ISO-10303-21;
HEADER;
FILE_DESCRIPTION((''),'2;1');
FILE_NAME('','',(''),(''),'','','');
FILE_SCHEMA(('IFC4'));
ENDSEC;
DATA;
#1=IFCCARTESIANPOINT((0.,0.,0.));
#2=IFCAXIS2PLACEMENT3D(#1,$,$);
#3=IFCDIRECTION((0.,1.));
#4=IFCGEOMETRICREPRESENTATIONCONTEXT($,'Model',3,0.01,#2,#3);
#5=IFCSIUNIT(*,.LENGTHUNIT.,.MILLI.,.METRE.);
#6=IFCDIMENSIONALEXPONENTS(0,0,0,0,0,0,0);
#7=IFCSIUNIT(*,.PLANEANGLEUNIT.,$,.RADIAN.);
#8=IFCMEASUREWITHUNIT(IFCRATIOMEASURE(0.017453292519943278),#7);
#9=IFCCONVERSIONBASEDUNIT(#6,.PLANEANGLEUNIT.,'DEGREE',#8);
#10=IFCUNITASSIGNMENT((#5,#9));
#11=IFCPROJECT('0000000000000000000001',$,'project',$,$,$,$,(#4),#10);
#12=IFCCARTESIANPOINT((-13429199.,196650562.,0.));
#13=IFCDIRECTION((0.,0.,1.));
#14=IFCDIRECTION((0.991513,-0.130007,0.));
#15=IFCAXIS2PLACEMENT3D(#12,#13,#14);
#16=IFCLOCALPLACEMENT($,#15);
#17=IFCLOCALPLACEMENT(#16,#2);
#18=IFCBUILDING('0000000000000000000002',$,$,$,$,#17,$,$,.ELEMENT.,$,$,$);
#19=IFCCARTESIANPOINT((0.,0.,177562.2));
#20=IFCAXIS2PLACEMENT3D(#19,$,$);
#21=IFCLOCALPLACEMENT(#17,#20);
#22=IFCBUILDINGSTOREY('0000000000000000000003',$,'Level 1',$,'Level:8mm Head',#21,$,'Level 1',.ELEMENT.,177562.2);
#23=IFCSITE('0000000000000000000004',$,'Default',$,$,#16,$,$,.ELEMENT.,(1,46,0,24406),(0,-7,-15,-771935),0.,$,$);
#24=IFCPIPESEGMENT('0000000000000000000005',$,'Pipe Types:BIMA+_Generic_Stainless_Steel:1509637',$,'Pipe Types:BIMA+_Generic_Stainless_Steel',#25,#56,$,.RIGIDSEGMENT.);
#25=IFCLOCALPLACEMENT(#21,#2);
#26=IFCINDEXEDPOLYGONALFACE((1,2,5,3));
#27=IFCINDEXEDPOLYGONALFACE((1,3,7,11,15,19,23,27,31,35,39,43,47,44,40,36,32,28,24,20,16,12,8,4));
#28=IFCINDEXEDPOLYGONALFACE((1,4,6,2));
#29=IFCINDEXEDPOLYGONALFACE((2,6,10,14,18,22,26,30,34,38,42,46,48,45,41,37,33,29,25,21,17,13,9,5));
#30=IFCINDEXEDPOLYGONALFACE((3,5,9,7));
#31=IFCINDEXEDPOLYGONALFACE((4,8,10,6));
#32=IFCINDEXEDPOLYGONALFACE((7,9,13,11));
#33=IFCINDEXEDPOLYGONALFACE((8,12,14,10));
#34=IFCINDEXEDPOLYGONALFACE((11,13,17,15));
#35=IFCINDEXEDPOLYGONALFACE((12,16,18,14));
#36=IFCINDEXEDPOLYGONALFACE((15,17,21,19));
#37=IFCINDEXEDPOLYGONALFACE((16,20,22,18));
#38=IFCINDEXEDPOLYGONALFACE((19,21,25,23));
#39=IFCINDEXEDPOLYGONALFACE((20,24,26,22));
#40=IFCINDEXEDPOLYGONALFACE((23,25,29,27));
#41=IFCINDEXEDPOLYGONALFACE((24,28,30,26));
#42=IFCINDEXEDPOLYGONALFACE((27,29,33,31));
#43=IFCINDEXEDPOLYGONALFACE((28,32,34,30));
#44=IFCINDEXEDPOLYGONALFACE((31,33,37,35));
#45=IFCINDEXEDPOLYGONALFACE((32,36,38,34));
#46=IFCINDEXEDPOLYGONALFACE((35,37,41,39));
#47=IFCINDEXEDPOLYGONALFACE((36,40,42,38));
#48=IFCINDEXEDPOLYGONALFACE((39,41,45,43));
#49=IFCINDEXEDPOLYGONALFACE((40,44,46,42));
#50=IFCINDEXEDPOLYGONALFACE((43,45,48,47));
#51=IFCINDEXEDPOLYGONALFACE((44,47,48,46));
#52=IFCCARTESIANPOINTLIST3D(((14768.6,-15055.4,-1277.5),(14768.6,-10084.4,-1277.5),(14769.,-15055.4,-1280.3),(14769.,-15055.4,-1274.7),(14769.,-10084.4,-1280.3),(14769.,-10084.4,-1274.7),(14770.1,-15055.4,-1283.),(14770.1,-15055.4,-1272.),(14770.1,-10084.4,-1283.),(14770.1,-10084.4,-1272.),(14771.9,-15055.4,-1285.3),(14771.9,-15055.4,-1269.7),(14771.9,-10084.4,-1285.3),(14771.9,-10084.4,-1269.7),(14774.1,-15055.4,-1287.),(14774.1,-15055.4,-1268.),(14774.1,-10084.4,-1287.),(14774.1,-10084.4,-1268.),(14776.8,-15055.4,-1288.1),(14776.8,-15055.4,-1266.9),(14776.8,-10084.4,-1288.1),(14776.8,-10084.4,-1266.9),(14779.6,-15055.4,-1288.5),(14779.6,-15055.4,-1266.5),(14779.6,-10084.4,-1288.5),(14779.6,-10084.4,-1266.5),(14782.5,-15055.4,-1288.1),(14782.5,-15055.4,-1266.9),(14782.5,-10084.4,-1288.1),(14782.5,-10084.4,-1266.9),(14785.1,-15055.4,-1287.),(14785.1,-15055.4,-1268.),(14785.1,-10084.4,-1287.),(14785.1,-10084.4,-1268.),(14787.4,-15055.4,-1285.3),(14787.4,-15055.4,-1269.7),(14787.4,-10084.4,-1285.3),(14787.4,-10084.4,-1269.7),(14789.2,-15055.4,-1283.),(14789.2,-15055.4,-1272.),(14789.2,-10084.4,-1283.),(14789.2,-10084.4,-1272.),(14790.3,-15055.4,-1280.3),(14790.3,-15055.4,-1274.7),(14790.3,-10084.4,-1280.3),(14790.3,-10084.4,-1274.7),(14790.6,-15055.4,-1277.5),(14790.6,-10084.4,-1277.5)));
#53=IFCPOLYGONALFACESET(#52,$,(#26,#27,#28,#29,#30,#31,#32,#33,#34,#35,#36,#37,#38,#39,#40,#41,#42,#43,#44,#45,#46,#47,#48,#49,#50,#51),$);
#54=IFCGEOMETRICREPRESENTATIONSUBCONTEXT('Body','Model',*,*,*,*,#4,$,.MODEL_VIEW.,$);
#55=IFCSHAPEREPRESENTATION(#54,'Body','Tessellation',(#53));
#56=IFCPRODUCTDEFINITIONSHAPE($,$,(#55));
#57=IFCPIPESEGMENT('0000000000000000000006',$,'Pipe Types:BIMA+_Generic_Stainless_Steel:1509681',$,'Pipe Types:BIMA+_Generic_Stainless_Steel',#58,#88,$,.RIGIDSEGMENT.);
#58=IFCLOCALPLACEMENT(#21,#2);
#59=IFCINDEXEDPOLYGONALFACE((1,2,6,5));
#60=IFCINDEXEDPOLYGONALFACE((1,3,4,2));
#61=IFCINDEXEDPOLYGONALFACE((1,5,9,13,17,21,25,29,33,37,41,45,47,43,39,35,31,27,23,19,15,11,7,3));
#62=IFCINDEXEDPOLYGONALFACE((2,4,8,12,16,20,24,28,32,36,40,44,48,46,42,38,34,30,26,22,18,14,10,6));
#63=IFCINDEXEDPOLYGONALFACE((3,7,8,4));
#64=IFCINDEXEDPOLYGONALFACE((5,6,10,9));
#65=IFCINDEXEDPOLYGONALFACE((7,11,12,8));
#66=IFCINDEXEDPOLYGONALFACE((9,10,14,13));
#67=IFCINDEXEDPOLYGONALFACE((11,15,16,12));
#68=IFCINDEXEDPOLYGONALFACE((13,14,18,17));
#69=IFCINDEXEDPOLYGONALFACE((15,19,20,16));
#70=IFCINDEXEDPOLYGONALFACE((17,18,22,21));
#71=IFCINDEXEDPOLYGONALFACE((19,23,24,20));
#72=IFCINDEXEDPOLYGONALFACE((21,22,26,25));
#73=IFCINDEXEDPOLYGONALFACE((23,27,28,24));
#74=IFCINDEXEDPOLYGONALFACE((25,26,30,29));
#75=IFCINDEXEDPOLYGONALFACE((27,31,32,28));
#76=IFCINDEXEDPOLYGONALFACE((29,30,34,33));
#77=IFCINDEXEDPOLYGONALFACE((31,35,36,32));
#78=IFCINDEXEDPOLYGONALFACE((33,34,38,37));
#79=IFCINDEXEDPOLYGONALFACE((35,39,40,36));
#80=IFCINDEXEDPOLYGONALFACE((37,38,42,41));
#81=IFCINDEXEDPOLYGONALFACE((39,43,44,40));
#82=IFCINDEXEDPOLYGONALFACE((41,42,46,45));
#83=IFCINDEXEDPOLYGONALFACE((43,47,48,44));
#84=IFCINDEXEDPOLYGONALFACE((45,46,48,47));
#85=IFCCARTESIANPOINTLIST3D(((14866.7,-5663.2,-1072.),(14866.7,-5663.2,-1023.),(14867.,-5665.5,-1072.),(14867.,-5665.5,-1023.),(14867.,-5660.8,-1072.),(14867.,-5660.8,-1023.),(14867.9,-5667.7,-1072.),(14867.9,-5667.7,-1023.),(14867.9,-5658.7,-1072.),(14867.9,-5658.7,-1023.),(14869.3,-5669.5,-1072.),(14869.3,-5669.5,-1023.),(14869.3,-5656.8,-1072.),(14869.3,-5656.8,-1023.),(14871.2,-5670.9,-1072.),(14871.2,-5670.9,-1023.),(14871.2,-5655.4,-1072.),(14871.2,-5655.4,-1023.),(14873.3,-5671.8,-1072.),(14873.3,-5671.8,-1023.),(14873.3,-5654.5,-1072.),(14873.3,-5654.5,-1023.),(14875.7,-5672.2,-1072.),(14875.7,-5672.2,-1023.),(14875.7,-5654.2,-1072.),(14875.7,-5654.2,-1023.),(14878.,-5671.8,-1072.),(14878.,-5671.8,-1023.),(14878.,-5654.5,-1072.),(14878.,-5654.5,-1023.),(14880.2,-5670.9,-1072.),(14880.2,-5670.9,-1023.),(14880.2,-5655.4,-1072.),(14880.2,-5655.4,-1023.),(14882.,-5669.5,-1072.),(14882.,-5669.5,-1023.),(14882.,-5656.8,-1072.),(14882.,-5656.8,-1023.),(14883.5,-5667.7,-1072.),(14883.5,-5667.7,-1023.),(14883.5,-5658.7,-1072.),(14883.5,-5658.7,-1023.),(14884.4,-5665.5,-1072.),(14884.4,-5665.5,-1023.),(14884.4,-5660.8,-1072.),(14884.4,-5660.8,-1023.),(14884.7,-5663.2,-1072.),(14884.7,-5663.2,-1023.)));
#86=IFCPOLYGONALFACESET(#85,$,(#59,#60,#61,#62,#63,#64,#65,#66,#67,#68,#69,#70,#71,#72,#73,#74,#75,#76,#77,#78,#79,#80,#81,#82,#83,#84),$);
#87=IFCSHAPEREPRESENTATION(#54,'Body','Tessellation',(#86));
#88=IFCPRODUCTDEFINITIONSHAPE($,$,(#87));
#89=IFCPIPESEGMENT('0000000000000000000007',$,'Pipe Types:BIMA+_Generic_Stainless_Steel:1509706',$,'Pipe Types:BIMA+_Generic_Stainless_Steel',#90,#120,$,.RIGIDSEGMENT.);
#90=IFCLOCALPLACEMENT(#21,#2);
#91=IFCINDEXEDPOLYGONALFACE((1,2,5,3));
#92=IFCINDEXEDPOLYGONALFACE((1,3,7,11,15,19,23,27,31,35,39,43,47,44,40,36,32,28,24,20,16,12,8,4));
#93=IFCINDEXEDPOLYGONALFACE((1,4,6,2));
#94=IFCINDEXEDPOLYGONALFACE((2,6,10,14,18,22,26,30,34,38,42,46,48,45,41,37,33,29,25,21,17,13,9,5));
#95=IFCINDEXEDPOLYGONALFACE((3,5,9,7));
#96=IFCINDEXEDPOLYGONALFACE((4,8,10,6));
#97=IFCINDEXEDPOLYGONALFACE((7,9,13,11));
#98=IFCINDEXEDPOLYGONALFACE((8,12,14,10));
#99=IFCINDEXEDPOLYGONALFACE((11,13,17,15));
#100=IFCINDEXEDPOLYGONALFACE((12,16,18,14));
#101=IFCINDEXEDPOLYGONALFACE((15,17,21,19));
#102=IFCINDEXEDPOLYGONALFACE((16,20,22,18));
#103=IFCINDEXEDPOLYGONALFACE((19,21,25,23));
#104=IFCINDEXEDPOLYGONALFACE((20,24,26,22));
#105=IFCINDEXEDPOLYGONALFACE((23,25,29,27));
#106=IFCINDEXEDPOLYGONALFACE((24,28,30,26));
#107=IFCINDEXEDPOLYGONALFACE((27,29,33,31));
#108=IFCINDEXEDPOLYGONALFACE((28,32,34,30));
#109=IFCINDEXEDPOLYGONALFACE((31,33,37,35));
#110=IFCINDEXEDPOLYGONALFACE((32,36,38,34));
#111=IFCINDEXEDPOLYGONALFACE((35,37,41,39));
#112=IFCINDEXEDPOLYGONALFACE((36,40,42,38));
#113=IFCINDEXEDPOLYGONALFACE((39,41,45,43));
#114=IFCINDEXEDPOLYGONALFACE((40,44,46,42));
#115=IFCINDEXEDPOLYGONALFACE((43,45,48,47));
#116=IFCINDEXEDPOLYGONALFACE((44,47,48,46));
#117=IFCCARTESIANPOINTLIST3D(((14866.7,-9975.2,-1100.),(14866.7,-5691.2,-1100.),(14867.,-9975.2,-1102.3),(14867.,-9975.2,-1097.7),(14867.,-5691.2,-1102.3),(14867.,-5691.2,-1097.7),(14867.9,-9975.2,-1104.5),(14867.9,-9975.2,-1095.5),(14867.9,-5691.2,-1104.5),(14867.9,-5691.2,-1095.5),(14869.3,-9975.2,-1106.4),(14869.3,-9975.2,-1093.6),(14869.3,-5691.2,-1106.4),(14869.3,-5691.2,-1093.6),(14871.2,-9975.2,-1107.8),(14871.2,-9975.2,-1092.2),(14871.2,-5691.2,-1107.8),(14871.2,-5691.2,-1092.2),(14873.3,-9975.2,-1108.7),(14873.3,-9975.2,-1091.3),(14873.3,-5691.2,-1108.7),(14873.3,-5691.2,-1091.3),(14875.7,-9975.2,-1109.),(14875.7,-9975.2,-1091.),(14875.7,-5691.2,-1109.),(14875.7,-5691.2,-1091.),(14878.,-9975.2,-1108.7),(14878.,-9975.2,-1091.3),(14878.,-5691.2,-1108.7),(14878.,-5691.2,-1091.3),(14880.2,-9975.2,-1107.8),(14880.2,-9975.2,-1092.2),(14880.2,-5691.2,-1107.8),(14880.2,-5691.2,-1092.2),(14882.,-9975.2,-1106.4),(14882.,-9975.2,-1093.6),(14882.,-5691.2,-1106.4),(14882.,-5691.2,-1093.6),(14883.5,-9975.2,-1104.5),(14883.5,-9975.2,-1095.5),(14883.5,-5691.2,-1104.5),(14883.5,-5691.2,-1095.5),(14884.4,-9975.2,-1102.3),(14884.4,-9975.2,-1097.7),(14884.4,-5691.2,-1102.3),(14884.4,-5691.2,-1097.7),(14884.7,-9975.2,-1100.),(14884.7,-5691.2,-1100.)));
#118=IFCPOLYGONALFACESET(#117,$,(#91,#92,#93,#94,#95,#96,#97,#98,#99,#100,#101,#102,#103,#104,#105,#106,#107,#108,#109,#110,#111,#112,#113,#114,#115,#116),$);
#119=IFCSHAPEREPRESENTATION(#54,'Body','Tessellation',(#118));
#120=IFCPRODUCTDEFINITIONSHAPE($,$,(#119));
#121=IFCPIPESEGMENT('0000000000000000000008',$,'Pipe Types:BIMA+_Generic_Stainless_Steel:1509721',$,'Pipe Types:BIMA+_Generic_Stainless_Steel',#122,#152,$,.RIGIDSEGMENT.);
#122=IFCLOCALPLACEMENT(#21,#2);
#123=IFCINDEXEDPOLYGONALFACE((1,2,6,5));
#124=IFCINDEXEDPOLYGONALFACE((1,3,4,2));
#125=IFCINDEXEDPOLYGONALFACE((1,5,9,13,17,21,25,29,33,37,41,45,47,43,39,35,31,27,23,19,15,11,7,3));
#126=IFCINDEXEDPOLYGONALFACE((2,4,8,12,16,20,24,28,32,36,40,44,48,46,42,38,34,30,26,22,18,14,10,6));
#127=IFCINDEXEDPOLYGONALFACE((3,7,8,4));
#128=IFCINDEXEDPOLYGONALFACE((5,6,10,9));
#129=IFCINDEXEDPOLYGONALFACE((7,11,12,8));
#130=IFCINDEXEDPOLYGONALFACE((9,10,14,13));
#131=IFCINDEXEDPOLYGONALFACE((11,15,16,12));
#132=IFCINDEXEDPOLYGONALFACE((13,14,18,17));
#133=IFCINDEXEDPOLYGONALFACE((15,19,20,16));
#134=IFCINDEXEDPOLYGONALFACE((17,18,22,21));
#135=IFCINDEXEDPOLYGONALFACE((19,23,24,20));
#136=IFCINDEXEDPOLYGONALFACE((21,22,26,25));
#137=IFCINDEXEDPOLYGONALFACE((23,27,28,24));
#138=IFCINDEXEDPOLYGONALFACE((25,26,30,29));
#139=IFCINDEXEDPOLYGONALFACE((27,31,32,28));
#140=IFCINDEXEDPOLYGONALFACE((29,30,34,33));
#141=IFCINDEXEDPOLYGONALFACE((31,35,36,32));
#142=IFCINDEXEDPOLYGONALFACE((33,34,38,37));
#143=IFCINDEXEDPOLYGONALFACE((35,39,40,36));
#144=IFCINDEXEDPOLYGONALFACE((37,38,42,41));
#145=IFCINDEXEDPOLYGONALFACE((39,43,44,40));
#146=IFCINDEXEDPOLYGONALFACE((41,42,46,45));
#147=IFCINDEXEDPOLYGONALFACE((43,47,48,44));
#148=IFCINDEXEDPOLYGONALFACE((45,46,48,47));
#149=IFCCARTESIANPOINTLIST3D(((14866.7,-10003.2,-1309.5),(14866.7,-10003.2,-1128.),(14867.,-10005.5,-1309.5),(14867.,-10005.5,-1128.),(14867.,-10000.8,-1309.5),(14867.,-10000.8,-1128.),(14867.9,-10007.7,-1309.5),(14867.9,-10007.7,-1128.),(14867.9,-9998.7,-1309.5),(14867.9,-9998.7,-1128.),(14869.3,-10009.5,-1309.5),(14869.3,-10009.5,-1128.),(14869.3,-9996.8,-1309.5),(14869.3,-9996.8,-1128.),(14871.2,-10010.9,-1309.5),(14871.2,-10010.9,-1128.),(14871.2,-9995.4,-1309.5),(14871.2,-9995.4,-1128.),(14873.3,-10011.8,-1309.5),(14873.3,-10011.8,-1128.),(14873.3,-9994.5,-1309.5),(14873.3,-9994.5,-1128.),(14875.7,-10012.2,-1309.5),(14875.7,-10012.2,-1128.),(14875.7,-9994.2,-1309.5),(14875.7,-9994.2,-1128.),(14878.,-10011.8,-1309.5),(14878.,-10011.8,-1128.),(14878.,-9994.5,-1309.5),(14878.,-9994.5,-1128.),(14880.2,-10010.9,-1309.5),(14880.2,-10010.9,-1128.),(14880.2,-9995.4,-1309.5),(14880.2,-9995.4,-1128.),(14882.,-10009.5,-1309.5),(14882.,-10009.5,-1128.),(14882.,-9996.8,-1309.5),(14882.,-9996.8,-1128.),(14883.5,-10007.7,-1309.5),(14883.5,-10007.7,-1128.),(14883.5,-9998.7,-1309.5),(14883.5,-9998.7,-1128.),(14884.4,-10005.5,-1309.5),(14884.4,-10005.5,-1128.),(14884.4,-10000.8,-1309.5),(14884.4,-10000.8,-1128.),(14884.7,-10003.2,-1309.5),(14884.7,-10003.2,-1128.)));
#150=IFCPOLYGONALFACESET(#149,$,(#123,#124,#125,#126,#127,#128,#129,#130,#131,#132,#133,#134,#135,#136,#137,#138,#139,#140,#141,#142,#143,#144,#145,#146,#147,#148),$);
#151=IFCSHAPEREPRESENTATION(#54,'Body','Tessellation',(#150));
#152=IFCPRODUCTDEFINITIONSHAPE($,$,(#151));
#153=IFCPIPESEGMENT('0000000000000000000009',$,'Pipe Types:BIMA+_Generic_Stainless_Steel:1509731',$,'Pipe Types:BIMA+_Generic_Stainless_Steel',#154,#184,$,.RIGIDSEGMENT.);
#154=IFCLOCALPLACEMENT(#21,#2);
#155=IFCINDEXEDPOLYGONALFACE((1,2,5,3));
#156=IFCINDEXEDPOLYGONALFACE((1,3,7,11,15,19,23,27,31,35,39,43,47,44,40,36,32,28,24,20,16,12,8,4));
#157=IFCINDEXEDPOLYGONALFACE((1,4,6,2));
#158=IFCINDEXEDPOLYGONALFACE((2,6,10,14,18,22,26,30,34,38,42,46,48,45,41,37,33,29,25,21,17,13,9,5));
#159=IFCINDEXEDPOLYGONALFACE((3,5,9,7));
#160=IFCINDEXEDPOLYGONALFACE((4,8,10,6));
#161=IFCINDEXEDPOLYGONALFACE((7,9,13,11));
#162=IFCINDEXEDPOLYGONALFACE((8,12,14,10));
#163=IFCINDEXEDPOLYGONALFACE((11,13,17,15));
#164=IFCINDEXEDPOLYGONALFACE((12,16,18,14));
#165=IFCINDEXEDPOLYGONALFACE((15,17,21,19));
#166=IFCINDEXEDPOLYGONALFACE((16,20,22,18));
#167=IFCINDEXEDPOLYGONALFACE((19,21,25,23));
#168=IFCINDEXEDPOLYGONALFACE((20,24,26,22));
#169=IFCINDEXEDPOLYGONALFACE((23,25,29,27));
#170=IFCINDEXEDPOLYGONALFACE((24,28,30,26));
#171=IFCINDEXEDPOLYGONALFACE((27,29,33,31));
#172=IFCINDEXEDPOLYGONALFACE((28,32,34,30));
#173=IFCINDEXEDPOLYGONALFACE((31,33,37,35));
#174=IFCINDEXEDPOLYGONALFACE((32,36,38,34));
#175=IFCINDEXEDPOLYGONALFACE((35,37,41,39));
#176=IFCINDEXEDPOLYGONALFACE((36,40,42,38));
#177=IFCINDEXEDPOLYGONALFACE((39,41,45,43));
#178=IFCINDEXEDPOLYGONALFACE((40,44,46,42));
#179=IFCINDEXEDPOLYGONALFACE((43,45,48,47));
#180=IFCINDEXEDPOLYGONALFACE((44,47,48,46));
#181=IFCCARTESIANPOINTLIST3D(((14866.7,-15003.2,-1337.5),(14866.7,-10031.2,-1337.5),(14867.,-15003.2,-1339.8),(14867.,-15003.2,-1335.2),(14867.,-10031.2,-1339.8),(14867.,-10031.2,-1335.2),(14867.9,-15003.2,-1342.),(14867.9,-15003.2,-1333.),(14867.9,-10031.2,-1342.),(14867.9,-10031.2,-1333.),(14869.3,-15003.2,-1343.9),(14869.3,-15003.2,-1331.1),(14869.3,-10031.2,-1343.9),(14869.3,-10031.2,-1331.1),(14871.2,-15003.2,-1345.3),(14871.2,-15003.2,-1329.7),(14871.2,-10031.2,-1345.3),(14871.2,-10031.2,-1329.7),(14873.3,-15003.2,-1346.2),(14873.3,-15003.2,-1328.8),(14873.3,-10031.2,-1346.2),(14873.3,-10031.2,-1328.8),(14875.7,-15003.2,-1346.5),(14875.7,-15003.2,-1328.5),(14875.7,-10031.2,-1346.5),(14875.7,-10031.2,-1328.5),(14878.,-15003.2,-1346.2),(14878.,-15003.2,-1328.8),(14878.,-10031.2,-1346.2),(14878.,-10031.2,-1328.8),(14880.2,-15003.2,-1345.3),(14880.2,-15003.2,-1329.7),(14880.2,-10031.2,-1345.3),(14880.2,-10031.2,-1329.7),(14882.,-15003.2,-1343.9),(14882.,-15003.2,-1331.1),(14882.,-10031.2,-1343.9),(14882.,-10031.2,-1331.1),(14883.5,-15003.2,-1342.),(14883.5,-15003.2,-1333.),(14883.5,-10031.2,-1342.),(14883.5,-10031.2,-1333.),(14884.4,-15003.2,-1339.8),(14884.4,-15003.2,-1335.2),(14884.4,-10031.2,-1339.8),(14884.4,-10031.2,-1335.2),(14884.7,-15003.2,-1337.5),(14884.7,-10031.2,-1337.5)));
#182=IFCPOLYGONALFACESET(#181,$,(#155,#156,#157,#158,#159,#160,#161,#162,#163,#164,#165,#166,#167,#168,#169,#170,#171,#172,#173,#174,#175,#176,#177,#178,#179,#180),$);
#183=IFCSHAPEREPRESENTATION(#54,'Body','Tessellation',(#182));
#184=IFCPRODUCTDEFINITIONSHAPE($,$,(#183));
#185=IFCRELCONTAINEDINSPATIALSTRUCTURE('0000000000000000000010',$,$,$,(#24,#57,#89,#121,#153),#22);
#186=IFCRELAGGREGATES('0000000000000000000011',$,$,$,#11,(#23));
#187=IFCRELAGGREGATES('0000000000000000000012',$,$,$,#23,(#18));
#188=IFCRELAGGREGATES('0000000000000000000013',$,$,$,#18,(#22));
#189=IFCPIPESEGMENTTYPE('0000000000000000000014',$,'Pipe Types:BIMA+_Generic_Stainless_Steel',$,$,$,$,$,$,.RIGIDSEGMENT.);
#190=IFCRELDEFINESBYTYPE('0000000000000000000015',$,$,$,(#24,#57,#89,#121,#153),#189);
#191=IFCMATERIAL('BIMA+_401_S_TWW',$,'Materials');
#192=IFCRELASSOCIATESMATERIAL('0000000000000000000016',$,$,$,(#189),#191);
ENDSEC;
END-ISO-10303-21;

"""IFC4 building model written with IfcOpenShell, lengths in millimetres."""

from ifc_helpers import new_model, entity, si_unit, converted_unit, direction, frame, origin, place, context, subcontext, project, spatial, arc, indexed_curve, outline, extrude, material, type_object, element, save


model = new_model("IFC4")

# Units and contexts
model_context = context("Model", 3, precision=0.01, world=origin(), true_north=direction((0.0, 1.0)))
body_context = subcontext(model_context, "Body", "Model", "MODEL_VIEW")
ifc_project = project(units=[si_unit("LENGTHUNIT", "METRE", prefix="MILLI"), converted_unit("PLANEANGLEUNIT", "DEGREE", entity("IfcRatioMeasure", 0.017453292519943278), si_unit("PLANEANGLEUNIT", "RADIAN"), dimensions=[0, 0, 0, 0, 0, 0, 0])], contexts=[model_context])

# Site, building, storey
site_placement = place(None, frame((-13429199.0, 196650562.0, 0.0), z_axis=(0.0, 0.0, 1.0), x_axis=(0.991513, -0.130007, 0.0)))
site = spatial("IfcSite", under=ifc_project, at=site_placement, Name="Default", CompositionType="ELEMENT", RefLatitude=(1, 46, 0, 24406), RefLongitude=(0, -7, -15, -771935), RefElevation=0.0)
building_placement = place(site_placement, origin())
building = spatial("IfcBuilding", under=site, at=building_placement, CompositionType="ELEMENT")
storey_placement = place(building_placement, frame((0.0, 0.0, 177562.2)))
storey = spatial("IfcBuildingStorey", under=building, at=storey_placement, Name="Level 1", ObjectType="Level:8mm Head", LongName="Level 1", CompositionType="ELEMENT", Elevation=177562.2)

# Pipe segments
ifc_material_1 = material(Name="BIMA+_401_S_TWW", Category="Materials")
pipe_segment_type_1 = type_object("IfcPipeSegmentType", Name="Pipe Types:BIMA+_Generic_Stainless_Steel", PredefinedType="RIGIDSEGMENT", material=ifc_material_1)
pipe_segment_1_placement = place(storey_placement, frame((14767.0, -15055.4, -1290.1)))
element("IfcPipeSegment", 1, at=pipe_segment_1_placement, inside=storey, type_object=pipe_segment_type_1, Name="Pipe Types:BIMA+_Generic_Stainless_Steel:1509637", ObjectType="Pipe Types:BIMA+_Generic_Stainless_Steel", PredefinedType="RIGIDSEGMENT", context=body_context, shape_type="SweptSolid", body=[
    extrude(outline(indexed_curve([(11.0, 0.0), (7.8, 7.8), (0.0, 11.0), (-7.8, 7.8), (-11.0, 0.0), (-7.8, -7.8), (0.0, -11.0), (7.8, -7.8)], segments=[arc(1, 2, 3), arc(3, 4, 5), arc(5, 6, 7), arc(7, 8, 1)], self_intersect=False)), frame((12.6, 0.0, 12.6), z_axis=(0.0, 1.0, 0.0), x_axis=(-1.0, 0.0, 0.0)), (0.0, 0.0, 1.0), 4971.0),
])
pipe_segment_2_placement = place(storey_placement, frame((14865.1, -5673.7, -1023.0)))
element("IfcPipeSegment", 2, at=pipe_segment_2_placement, inside=storey, type_object=pipe_segment_type_1, Name="Pipe Types:BIMA+_Generic_Stainless_Steel:1509681", ObjectType="Pipe Types:BIMA+_Generic_Stainless_Steel", PredefinedType="RIGIDSEGMENT", context=body_context, shape_type="SweptSolid", body=[
    extrude(outline(indexed_curve([(9.0, 0.0), (6.4, 6.4), (0.0, 9.0), (-6.4, 6.4), (-9.0, 0.0), (-6.4, -6.4), (0.0, -9.0), (6.4, -6.4)], segments=[arc(1, 2, 3), arc(3, 4, 5), arc(5, 6, 7), arc(7, 8, 1)], self_intersect=False)), frame((10.6, 10.6, -49.0)), (0.0, 0.0, 1.0), 49.0),
])
pipe_segment_3_placement = place(storey_placement, frame((14865.1, -9975.2, -1110.6)))
element("IfcPipeSegment", 3, at=pipe_segment_3_placement, inside=storey, type_object=pipe_segment_type_1, Name="Pipe Types:BIMA+_Generic_Stainless_Steel:1509706", ObjectType="Pipe Types:BIMA+_Generic_Stainless_Steel", PredefinedType="RIGIDSEGMENT", context=body_context, shape_type="SweptSolid", body=[
    extrude(outline(indexed_curve([(9.0, 0.0), (6.4, 6.4), (0.0, 9.0), (-6.4, 6.4), (-9.0, 0.0), (-6.4, -6.4), (0.0, -9.0), (6.4, -6.4)], segments=[arc(1, 2, 3), arc(3, 4, 5), arc(5, 6, 7), arc(7, 8, 1)], self_intersect=False)), frame((10.6, 0.0, 10.6), z_axis=(0.0, 1.0, 0.0), x_axis=(-1.0, 0.0, 0.0)), (0.0, 0.0, 1.0), 4284.0),
])
pipe_segment_4_placement = place(storey_placement, frame((14865.1, -10013.7, -1128.0)))
element("IfcPipeSegment", 4, at=pipe_segment_4_placement, inside=storey, type_object=pipe_segment_type_1, Name="Pipe Types:BIMA+_Generic_Stainless_Steel:1509721", ObjectType="Pipe Types:BIMA+_Generic_Stainless_Steel", PredefinedType="RIGIDSEGMENT", context=body_context, shape_type="SweptSolid", body=[
    extrude(outline(indexed_curve([(9.0, 0.0), (6.4, 6.4), (0.0, 9.0), (-6.4, 6.4), (-9.0, 0.0), (-6.4, -6.4), (0.0, -9.0), (6.4, -6.4)], segments=[arc(1, 2, 3), arc(3, 4, 5), arc(5, 6, 7), arc(7, 8, 1)], self_intersect=False)), frame((10.6, 10.6, -181.5)), (0.0, 0.0, 1.0), 181.5),
])
pipe_segment_5_placement = place(storey_placement, frame((14865.1, -15003.2, -1348.1)))
element("IfcPipeSegment", 5, at=pipe_segment_5_placement, inside=storey, type_object=pipe_segment_type_1, Name="Pipe Types:BIMA+_Generic_Stainless_Steel:1509731", ObjectType="Pipe Types:BIMA+_Generic_Stainless_Steel", PredefinedType="RIGIDSEGMENT", context=body_context, shape_type="SweptSolid", body=[
    extrude(outline(indexed_curve([(9.0, 0.0), (6.4, 6.4), (0.0, 9.0), (-6.4, 6.4), (-9.0, 0.0), (-6.4, -6.4), (0.0, -9.0), (6.4, -6.4)], segments=[arc(1, 2, 3), arc(3, 4, 5), arc(5, 6, 7), arc(7, 8, 1)], self_intersect=False)), frame((10.6, 0.0, 10.6), z_axis=(0.0, 1.0, 0.0), x_axis=(-1.0, 0.0, 0.0)), (0.0, 0.0, 1.0), 4972.0),
])

save(model, "model.ifc")
